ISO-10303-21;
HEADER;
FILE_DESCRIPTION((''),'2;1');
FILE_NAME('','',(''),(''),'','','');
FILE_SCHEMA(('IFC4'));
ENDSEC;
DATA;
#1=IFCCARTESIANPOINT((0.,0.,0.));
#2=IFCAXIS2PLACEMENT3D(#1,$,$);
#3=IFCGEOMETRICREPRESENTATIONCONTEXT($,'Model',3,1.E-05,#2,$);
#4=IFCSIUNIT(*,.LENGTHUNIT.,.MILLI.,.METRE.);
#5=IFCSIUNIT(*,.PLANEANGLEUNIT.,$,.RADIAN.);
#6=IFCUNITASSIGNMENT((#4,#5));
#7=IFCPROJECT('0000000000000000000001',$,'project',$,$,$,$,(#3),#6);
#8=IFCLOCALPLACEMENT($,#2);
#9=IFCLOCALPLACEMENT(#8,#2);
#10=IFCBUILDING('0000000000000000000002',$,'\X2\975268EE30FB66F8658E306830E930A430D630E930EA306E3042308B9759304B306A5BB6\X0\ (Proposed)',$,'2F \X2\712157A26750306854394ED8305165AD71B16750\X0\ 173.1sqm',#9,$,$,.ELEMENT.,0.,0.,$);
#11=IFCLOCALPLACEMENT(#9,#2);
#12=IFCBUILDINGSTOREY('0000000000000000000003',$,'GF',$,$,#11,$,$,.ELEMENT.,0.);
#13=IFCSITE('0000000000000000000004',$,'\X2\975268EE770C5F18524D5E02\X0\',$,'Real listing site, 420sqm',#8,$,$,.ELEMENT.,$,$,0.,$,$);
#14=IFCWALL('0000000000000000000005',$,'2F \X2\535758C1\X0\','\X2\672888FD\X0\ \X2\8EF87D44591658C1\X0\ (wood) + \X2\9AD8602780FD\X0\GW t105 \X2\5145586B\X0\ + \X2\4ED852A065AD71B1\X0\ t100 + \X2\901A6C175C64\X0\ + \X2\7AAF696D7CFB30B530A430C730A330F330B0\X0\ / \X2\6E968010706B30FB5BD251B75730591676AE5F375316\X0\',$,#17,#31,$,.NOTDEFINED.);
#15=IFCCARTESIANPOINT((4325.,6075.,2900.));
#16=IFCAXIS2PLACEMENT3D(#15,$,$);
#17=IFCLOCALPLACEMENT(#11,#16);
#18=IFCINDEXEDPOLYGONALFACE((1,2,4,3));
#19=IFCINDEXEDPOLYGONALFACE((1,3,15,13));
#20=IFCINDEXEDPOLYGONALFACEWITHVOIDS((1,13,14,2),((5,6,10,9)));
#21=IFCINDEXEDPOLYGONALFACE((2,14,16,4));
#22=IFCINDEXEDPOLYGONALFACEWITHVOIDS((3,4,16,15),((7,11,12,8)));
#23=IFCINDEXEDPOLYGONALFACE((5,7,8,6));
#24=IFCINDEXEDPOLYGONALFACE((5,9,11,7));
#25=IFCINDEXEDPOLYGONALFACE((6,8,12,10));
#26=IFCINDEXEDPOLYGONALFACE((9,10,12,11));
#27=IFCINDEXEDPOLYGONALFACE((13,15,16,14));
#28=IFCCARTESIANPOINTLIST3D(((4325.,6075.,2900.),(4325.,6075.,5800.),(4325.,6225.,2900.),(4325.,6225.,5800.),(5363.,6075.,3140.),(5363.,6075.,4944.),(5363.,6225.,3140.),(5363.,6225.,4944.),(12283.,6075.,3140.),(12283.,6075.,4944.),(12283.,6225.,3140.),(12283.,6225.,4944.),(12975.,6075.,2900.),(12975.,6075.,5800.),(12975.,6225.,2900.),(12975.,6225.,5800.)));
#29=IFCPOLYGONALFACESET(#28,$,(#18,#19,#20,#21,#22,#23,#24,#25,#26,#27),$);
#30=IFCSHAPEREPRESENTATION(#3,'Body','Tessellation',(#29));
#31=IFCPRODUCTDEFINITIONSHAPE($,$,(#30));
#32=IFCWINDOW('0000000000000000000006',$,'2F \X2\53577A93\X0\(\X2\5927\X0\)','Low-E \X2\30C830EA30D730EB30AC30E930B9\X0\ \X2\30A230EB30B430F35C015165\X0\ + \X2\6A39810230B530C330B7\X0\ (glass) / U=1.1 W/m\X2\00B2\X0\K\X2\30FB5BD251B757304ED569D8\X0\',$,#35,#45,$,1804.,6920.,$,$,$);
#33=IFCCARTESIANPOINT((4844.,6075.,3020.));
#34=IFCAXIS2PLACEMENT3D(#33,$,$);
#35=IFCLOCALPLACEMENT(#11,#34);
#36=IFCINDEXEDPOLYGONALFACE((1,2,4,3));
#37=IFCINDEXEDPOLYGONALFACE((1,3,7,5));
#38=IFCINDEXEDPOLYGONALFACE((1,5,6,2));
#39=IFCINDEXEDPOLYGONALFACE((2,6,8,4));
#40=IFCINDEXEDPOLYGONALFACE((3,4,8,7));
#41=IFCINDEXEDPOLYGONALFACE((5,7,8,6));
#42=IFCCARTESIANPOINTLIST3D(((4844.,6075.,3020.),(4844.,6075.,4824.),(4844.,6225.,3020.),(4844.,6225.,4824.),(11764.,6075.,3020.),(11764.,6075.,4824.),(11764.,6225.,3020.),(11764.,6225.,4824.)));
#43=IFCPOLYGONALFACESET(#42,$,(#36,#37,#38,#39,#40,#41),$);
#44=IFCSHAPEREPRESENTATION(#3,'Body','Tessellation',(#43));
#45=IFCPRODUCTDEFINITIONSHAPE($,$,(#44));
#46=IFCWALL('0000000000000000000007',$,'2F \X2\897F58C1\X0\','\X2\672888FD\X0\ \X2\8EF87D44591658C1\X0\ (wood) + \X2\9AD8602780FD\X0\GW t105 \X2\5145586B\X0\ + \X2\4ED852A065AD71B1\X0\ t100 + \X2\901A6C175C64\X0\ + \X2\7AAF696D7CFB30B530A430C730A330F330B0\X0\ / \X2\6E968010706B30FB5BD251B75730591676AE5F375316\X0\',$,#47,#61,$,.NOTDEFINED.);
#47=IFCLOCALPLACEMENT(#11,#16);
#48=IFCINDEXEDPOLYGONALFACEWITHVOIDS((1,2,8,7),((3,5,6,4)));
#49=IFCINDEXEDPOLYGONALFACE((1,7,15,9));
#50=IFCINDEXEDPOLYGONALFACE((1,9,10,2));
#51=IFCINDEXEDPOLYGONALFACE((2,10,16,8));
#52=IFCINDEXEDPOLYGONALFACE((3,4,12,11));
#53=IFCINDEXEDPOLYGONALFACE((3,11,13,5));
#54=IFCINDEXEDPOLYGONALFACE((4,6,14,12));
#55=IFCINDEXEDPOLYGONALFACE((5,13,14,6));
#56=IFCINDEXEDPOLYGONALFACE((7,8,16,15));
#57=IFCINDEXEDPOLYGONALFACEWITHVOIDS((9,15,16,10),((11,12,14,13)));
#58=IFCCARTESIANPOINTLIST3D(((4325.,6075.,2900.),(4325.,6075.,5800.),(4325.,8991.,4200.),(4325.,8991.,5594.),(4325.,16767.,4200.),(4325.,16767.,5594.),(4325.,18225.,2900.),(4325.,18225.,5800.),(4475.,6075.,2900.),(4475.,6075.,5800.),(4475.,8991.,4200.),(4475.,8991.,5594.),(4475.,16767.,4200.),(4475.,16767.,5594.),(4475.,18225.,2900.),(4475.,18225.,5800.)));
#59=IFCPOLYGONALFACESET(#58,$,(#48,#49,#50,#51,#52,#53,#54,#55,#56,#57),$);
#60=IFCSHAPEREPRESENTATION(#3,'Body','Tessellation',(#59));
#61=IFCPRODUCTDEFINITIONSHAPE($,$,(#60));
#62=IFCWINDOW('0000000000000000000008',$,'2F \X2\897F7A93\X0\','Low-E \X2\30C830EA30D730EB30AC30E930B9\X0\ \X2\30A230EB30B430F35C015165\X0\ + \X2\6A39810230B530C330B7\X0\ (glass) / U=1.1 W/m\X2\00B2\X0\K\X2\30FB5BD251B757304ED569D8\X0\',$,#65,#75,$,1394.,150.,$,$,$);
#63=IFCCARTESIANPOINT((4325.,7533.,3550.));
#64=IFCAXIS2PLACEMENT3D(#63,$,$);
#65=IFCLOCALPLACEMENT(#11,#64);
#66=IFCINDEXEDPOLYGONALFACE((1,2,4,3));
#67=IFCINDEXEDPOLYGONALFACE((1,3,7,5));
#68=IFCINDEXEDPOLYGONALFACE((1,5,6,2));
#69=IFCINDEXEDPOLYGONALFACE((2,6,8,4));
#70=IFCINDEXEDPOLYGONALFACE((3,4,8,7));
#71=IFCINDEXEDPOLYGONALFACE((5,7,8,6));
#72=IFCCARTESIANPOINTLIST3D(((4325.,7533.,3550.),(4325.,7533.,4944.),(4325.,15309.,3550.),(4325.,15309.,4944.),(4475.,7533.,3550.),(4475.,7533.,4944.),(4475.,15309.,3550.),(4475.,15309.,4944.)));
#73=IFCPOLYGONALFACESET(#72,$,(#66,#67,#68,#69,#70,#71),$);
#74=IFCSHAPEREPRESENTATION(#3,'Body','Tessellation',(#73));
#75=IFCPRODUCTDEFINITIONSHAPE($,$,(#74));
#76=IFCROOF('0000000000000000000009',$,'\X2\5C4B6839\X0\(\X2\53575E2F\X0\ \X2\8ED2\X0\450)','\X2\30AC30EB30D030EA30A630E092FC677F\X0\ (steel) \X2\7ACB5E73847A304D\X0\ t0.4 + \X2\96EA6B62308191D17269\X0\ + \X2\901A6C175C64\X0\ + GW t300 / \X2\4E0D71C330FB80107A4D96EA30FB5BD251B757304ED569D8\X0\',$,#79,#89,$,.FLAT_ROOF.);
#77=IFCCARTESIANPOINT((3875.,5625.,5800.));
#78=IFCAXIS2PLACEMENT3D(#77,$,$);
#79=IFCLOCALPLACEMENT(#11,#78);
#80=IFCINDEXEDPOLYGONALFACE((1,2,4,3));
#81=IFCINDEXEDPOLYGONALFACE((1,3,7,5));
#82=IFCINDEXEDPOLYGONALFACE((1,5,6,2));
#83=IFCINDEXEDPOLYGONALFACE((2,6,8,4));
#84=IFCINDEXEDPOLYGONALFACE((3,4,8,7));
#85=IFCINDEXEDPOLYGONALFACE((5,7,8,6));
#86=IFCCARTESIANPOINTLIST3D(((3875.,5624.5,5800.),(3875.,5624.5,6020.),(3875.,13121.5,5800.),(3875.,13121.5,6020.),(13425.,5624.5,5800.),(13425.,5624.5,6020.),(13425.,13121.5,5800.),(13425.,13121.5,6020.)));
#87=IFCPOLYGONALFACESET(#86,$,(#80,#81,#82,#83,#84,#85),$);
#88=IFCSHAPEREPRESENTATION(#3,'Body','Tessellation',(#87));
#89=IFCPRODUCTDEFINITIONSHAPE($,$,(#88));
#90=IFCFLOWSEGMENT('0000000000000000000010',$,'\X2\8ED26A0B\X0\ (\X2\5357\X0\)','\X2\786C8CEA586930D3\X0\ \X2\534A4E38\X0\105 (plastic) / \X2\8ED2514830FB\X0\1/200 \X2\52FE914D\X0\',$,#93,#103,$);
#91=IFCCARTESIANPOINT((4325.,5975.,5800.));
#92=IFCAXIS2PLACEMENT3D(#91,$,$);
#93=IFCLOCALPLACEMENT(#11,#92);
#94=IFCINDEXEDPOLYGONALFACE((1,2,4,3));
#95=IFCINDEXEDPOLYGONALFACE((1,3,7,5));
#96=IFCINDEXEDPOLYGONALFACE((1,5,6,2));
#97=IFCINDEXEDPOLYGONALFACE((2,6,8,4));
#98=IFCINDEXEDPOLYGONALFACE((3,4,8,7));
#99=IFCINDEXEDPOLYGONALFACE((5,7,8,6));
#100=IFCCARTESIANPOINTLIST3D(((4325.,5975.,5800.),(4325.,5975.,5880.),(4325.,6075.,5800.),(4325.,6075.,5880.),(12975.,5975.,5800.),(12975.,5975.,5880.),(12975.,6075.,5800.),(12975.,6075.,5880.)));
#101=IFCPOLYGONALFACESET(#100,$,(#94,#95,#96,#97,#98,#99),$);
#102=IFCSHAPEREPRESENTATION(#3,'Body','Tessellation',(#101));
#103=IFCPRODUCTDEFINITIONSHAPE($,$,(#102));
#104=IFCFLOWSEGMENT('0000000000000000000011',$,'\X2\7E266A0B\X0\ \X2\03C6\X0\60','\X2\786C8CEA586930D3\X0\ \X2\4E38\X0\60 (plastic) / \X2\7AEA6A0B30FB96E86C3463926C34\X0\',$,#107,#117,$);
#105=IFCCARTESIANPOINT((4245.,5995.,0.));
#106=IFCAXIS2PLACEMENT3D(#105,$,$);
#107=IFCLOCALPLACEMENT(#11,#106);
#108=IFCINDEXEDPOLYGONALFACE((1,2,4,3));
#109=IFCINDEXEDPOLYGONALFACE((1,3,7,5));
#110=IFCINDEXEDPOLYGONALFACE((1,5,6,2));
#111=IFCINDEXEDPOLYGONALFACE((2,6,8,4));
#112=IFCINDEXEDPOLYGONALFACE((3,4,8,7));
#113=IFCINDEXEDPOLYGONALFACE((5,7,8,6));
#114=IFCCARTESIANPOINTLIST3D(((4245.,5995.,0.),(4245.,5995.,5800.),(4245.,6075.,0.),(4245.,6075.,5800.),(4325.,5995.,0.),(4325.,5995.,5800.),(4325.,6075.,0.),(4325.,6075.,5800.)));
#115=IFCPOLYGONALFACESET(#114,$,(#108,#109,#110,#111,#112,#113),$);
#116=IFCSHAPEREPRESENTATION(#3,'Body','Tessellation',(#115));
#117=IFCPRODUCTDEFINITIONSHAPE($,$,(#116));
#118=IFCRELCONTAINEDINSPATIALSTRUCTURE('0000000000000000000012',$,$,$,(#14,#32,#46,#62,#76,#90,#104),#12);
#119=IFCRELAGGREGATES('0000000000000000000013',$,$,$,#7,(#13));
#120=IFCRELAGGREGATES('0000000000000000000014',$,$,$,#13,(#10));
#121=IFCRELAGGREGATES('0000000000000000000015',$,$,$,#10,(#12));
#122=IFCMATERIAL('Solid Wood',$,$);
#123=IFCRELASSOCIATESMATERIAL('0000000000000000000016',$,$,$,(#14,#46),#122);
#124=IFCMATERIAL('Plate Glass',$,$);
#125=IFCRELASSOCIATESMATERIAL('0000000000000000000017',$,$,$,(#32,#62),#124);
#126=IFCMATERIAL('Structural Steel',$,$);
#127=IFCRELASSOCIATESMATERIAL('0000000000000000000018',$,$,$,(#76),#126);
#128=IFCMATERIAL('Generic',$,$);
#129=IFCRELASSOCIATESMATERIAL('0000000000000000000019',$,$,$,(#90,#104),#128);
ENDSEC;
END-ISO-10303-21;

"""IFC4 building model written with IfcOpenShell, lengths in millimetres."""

from ifc_helpers import new_model, si_unit, frame, frame_2d, origin, place, context, project, spatial, rectangle, extrude, material, element, fill, save


model = new_model("IFC4")

# Units and contexts
model_context = context("Model", 3, precision=1e-05, world=origin())
ifc_project = project(units=[si_unit("LENGTHUNIT", "METRE", prefix="MILLI"), si_unit("PLANEANGLEUNIT", "RADIAN")], contexts=[model_context])

# Site, building, storey
site_placement = place(None, origin())
site = spatial("IfcSite", under=ifc_project, at=site_placement, Name="青森県弘前市", ObjectType="Real listing site, 420sqm", CompositionType="ELEMENT", RefElevation=0.0)
building_placement = place(site_placement, origin())
building = spatial("IfcBuilding", under=site, at=building_placement, Name="青森・書斎とライブラリのある静かな家 (Proposed)", ObjectType="2F 無垢材と吹付け断熱材 173.1sqm", CompositionType="ELEMENT", ElevationOfRefHeight=0.0, ElevationOfTerrain=0.0)
storey_placement = place(building_placement, origin())
storey = spatial("IfcBuildingStorey", under=building, at=storey_placement, Name="GF", CompositionType="ELEMENT", Elevation=0.0)

# Shared definitions
ifc_material_1 = material(Name="Solid Wood")

# Shared definitions
ifc_material_2 = material(Name="Plate Glass")

# Walls, openings, windows
wall_1_placement = place(storey_placement, frame((4325.0, 6075.0, 2900.0)))
wall_1 = element("IfcWall", 1, at=wall_1_placement, inside=storey, material=ifc_material_1, Name="2F 南壁", Description="木製 軸組外壁 (wood) + 高性能GW t105 充填 + 付加断熱 t100 + 通気層 + 窯業系サイディング / 準耐火・寒冷地外皮強化", PredefinedType="NOTDEFINED", context=model_context, shape_type="SweptSolid", body=[
    extrude(rectangle(XDim=8650.0, YDim=150.0, at=frame_2d((4325.0, 75.0))), frame((4325.0, 6075.0, 2900.0)), (0.0, 0.0, 1.0), 2900.0),
])
opening_1_placement = place(storey_placement, frame((4844.0, 6075.0, 3020.0)))
opening_1 = element("IfcOpeningElement", 2, at=opening_1_placement, cuts=wall_1, PredefinedType="NOTDEFINED", context=model_context, shape_type="SweptSolid", body=[
    extrude(rectangle(XDim=6920.0, YDim=150.0, at=frame_2d((3460.0, 75.0))), frame((4844.0, 6075.0, 3020.0)), (0.0, 0.0, 1.0), 1804.0),
])
window_1_placement = place(storey_placement, frame((4844.0, 6075.0, 3020.0)))
window_1 = element("IfcWindow", 3, at=window_1_placement, inside=storey, material=ifc_material_2, Name="2F 南窓(大)", Description="Low-E トリプルガラス アルゴン封入 + 樹脂サッシ (glass) / U=1.1 W/m²K・寒冷地仕様", OverallHeight=1804.0, OverallWidth=6920.0, context=model_context, shape_type="SweptSolid", body=[
    extrude(rectangle(XDim=6920.0, YDim=150.0, at=frame_2d((3460.0, 75.0))), frame((4844.0, 6075.0, 3020.0)), (0.0, 0.0, 1.0), 1804.0),
])
fill(opening_1, window_1)
wall_2_placement = place(storey_placement, frame((4325.0, 6075.0, 2900.0)))
wall_2 = element("IfcWall", 4, at=wall_2_placement, inside=storey, material=ifc_material_1, Name="2F 西壁", Description="木製 軸組外壁 (wood) + 高性能GW t105 充填 + 付加断熱 t100 + 通気層 + 窯業系サイディング / 準耐火・寒冷地外皮強化", PredefinedType="NOTDEFINED", context=model_context, shape_type="SweptSolid", body=[
    extrude(rectangle(XDim=150.0, YDim=12150.0, at=frame_2d((75.0, 6075.0))), frame((4325.0, 6075.0, 2900.0)), (0.0, 0.0, 1.0), 2900.0),
])
opening_2_placement = place(storey_placement, frame((4325.0, 7533.0, 3550.0)))
opening_2 = element("IfcOpeningElement", 5, at=opening_2_placement, cuts=wall_2, PredefinedType="NOTDEFINED", context=model_context, shape_type="SweptSolid", body=[
    extrude(rectangle(XDim=150.0, YDim=7776.0, at=frame_2d((75.0, 3888.0))), frame((4325.0, 7533.0, 3550.0)), (0.0, 0.0, 1.0), 1394.0),
])
window_2_placement = place(storey_placement, frame((4325.0, 7533.0, 3550.0)))
window_2 = element("IfcWindow", 6, at=window_2_placement, inside=storey, material=ifc_material_2, Name="2F 西窓", Description="Low-E トリプルガラス アルゴン封入 + 樹脂サッシ (glass) / U=1.1 W/m²K・寒冷地仕様", OverallHeight=1394.0, OverallWidth=150.0, context=model_context, shape_type="SweptSolid", body=[
    extrude(rectangle(XDim=150.0, YDim=7776.0, at=frame_2d((75.0, 3888.0))), frame((4325.0, 7533.0, 3550.0)), (0.0, 0.0, 1.0), 1394.0),
])
fill(opening_2, window_2)

# Roof
ifc_material_3 = material(Name="Structural Steel")
for number, where, name in (
    (7, (3875.0, 5625.0, 5800.0), "屋根(南帯 軒450)"),
):
    element("IfcRoof", number, at=place(storey_placement, frame(where)), inside=storey, material=ifc_material_3, Name=name, Description="ガルバリウム鋼板 (steel) 立平葺き t0.4 + 雪止め金物 + 通気層 + GW t300 / 不燃・耐積雪・寒冷地仕様", PredefinedType="FLAT_ROOF", context=model_context, shape_type="SweptSolid", body=[
        extrude(rectangle(XDim=9550.0, YDim=7497.0, at=frame_2d((4775.0, 3748.0))), frame((3875.0, 5625.0, 5800.0)), (0.0, 0.0, 1.0), 220.0),
    ])

# Flow segments
ifc_material_4 = material(Name="Generic")
flow_segment_1_placement = place(storey_placement, frame((4325.0, 5975.0, 5800.0)))
element("IfcFlowSegment", 8, at=flow_segment_1_placement, inside=storey, material=ifc_material_4, Name="軒樋 (南)", Description="硬質塩ビ 半丸105 (plastic) / 軒先・1/200 勾配", context=model_context, shape_type="SweptSolid", body=[
    extrude(rectangle(XDim=8650.0, YDim=100.0, at=frame_2d((4325.0, 50.0))), frame((4325.0, 5975.0, 5800.0)), (0.0, 0.0, 1.0), 80.0),
])
flow_segment_2_placement = place(storey_placement, frame((4245.0, 5995.0, 0.0)))
element("IfcFlowSegment", 9, at=flow_segment_2_placement, inside=storey, material=ifc_material_4, Name="縦樋 φ60", Description="硬質塩ビ 丸60 (plastic) / 竪樋・雨水排水", context=model_context, shape_type="SweptSolid", body=[
    extrude(rectangle(XDim=80.0, YDim=80.0, at=frame_2d((40.0, 40.0))), frame((4245.0, 5995.0, 0.0)), (0.0, 0.0, 1.0), 5800.0),
])

save(model, "model.ifc")
